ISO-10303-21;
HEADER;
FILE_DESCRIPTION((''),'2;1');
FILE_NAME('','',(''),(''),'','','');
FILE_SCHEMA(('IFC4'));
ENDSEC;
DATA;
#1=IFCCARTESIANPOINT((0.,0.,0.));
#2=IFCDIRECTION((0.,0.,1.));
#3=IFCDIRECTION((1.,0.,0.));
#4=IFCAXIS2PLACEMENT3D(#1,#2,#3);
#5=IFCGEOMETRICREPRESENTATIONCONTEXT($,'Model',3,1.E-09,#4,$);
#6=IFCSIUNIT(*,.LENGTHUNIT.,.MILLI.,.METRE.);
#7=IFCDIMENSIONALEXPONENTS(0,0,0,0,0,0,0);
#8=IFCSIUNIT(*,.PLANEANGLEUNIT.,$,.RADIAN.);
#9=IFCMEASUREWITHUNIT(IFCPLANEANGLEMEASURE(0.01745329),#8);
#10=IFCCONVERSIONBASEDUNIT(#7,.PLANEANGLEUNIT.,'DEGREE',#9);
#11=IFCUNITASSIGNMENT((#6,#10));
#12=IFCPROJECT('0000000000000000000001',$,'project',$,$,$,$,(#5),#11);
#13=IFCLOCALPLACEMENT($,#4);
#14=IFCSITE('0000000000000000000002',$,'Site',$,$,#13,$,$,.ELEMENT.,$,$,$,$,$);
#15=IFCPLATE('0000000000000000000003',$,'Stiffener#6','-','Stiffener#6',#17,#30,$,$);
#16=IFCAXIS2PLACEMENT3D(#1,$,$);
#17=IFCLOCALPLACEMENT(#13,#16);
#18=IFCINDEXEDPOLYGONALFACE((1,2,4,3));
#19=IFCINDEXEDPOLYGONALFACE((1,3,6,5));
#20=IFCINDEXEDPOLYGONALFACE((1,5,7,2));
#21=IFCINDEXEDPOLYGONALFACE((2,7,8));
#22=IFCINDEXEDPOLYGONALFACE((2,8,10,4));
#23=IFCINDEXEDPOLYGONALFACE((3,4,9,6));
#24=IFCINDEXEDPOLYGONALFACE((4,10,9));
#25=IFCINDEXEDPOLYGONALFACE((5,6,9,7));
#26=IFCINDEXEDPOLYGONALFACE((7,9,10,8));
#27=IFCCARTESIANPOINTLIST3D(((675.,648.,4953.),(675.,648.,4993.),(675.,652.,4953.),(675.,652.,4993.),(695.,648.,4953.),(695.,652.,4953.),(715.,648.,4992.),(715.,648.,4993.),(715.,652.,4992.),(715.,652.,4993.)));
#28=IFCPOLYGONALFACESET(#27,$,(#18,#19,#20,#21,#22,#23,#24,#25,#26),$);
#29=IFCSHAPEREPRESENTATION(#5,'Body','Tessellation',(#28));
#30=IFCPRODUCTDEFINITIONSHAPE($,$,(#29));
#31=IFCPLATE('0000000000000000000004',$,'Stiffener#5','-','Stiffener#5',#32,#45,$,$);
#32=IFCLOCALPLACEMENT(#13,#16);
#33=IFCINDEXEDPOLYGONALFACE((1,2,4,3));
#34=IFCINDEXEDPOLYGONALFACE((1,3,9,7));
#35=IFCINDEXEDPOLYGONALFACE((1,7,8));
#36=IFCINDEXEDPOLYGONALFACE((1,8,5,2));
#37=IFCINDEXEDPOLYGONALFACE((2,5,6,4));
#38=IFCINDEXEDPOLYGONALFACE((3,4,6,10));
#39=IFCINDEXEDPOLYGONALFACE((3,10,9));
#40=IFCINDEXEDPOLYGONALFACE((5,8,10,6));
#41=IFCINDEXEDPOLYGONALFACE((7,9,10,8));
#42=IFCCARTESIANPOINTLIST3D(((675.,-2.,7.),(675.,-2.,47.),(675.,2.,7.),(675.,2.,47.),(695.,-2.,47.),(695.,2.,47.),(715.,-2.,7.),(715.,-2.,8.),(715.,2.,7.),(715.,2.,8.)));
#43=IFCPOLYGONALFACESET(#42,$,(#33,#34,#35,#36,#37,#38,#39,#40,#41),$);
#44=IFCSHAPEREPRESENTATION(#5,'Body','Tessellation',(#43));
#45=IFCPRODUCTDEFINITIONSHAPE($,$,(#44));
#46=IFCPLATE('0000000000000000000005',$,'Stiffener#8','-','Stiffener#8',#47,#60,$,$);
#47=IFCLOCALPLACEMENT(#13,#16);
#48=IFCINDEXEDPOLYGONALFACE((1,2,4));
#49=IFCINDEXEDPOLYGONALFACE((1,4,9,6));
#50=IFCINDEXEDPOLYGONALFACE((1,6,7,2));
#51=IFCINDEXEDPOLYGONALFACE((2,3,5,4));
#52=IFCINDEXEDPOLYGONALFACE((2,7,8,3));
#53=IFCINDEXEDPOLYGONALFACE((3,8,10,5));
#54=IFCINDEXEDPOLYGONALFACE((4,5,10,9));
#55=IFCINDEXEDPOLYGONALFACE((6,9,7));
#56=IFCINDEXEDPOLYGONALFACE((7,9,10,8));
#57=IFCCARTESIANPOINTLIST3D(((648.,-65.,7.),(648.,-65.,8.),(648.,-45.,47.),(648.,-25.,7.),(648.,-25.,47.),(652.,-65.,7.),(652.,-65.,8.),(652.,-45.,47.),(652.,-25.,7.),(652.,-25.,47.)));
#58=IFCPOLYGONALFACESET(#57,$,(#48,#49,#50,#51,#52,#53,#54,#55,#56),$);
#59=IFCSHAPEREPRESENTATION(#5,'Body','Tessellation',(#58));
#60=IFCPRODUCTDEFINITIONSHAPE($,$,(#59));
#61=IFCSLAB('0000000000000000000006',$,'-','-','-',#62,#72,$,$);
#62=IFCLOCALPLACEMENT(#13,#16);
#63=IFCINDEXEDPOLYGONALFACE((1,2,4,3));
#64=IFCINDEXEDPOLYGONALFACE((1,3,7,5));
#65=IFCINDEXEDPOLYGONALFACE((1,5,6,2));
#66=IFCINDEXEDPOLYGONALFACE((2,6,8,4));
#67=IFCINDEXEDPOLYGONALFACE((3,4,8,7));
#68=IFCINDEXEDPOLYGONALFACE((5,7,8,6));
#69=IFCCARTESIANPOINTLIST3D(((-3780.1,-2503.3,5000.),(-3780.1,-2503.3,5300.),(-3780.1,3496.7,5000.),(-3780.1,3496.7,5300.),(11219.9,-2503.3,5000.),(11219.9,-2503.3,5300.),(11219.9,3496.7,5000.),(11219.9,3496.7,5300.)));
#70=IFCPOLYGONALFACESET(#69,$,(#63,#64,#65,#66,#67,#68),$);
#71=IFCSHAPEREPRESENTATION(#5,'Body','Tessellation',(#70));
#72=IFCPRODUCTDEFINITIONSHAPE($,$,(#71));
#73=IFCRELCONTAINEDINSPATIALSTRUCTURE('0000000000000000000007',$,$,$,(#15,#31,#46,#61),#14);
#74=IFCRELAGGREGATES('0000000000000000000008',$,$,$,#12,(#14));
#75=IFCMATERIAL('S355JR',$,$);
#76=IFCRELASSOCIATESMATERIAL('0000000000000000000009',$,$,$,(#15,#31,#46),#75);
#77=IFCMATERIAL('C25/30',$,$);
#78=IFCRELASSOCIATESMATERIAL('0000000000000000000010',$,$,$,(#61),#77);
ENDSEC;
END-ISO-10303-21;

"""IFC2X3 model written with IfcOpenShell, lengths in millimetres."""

from ifc_helpers import new_model, entity, si_unit, converted_unit, frame, origin, origin_with_axes, place, context, project, spatial, polyline, outline, extrude, material, element, save


model = new_model("IFC2X3")

# Units and contexts
model_context = context("Model", 3, precision=1e-09, world=origin_with_axes())
ifc_project = project(units=[si_unit("LENGTHUNIT", "METRE", prefix="MILLI"), converted_unit("PLANEANGLEUNIT", "DEGREE", entity("IfcPlaneAngleMeasure", 0.01745329), si_unit("PLANEANGLEUNIT", "RADIAN"), dimensions=[0, 0, 0, 0, 0, 0, 0])], contexts=[model_context])

# Site
site_placement = place(None, origin_with_axes())
site = spatial("IfcSite", under=ifc_project, at=site_placement, Name="Site", CompositionType="ELEMENT")

# Shared definitions
ifc_material_1 = material(Name="S355JR")

# Plates, openings
plate_1_placement = place(None, frame((675.0, 648.0, 4993.0), z_axis=(0.0, 1.0, 0.0), x_axis=(1.0, 0.0, 0.0)))
plate_1 = element("IfcPlate", 1, at=plate_1_placement, inside=site, material=ifc_material_1, Name="Stiffener#6", Description="-", ObjectType="Stiffener#6", context=model_context, shape_type="SweptSolid", body=[
    extrude(outline(polyline([(0.0, 0.0), (40.0, 0.0), (40.0, 40.0), (0.0, 40.0), (0.0, 0.0)])), origin_with_axes(), (0.0, 0.0, 1.0), 4.0),
])
opening_1_placement = place(plate_1_placement, frame((0.0, 0.0, 0.0), z_axis=(0.0, 0.0, 1.0), x_axis=(1.0, 0.0, 0.0)))
element("IfcOpeningElement", 2, at=opening_1_placement, cuts=plate_1, ObjectType="Opening", context=model_context, shape_type="SweptSolid", body=[
    extrude(outline(polyline([(40.0, 40.0), (20.0, 40.0), (40.0, 1.0), (40.0, 40.0)])), origin(), (0.0, 0.0, 1.0), 4.0),
])
plate_2_placement = place(None, frame((675.0, -2.0, 7.0), z_axis=(0.0, 1.0, 0.0), x_axis=(0.0, 0.0, 1.0)))
plate_2 = element("IfcPlate", 3, at=plate_2_placement, inside=site, material=ifc_material_1, Name="Stiffener#5", Description="-", ObjectType="Stiffener#5", context=model_context, shape_type="SweptSolid", body=[
    extrude(outline(polyline([(0.0, 0.0), (40.0, 0.0), (40.0, 40.0), (0.0, 40.0), (0.0, 0.0)])), origin_with_axes(), (0.0, 0.0, 1.0), 4.0),
])
opening_2_placement = place(plate_2_placement, frame((0.0, 0.0, 0.0), z_axis=(0.0, 0.0, 1.0), x_axis=(1.0, 0.0, 0.0)))
element("IfcOpeningElement", 4, at=opening_2_placement, cuts=plate_2, ObjectType="Opening", context=model_context, shape_type="SweptSolid", body=[
    extrude(outline(polyline([(40.0, 40.0), (1.0, 40.0), (40.0, 20.0), (40.0, 40.0)])), origin(), (0.0, 0.0, 1.0), 4.0),
])
plate_3_placement = place(None, frame((652.0, -25.0, 7.0), z_axis=(-1.0, 0.0, 0.0), x_axis=(0.0, -1.0, 0.0)))
plate_3 = element("IfcPlate", 5, at=plate_3_placement, inside=site, material=ifc_material_1, Name="Stiffener#8", Description="-", ObjectType="Stiffener#8", context=model_context, shape_type="SweptSolid", body=[
    extrude(outline(polyline([(0.0, 0.0), (40.0, 0.0), (40.0, 40.0), (0.0, 40.0), (0.0, 0.0)])), origin_with_axes(), (0.0, 0.0, 1.0), 4.0),
])
opening_3_placement = place(plate_3_placement, frame((0.0, 0.0, 0.0), z_axis=(0.0, 0.0, 1.0), x_axis=(1.0, 0.0, 0.0)))
element("IfcOpeningElement", 6, at=opening_3_placement, cuts=plate_3, ObjectType="Opening", context=model_context, shape_type="SweptSolid", body=[
    extrude(outline(polyline([(40.0, 40.0), (20.0, 40.0), (40.0, 1.0), (40.0, 40.0)])), origin(), (0.0, 0.0, 1.0), 4.0),
])

# Slab
ifc_material_2 = material(Name="C25/30")
slab_placement = place(None, frame((3719.9, 496.7, 5000.0), z_axis=(0.0, 0.0, 1.0), x_axis=(1.0, 0.0, 0.0)))
element("IfcSlab", 7, at=slab_placement, inside=site, material=ifc_material_2, Name="-", Description="-", ObjectType="-", context=model_context, shape_type="SweptSolid", body=[
    extrude(outline(polyline([(-7500.0, -3000.0), (7500.0, -3000.0), (7500.0, 3000.0), (-7500.0, 3000.0), (-7500.0, -3000.0)])), origin_with_axes(), (0.0, 0.0, 1.0), 300.0),
])

save(model, "model.ifc")
